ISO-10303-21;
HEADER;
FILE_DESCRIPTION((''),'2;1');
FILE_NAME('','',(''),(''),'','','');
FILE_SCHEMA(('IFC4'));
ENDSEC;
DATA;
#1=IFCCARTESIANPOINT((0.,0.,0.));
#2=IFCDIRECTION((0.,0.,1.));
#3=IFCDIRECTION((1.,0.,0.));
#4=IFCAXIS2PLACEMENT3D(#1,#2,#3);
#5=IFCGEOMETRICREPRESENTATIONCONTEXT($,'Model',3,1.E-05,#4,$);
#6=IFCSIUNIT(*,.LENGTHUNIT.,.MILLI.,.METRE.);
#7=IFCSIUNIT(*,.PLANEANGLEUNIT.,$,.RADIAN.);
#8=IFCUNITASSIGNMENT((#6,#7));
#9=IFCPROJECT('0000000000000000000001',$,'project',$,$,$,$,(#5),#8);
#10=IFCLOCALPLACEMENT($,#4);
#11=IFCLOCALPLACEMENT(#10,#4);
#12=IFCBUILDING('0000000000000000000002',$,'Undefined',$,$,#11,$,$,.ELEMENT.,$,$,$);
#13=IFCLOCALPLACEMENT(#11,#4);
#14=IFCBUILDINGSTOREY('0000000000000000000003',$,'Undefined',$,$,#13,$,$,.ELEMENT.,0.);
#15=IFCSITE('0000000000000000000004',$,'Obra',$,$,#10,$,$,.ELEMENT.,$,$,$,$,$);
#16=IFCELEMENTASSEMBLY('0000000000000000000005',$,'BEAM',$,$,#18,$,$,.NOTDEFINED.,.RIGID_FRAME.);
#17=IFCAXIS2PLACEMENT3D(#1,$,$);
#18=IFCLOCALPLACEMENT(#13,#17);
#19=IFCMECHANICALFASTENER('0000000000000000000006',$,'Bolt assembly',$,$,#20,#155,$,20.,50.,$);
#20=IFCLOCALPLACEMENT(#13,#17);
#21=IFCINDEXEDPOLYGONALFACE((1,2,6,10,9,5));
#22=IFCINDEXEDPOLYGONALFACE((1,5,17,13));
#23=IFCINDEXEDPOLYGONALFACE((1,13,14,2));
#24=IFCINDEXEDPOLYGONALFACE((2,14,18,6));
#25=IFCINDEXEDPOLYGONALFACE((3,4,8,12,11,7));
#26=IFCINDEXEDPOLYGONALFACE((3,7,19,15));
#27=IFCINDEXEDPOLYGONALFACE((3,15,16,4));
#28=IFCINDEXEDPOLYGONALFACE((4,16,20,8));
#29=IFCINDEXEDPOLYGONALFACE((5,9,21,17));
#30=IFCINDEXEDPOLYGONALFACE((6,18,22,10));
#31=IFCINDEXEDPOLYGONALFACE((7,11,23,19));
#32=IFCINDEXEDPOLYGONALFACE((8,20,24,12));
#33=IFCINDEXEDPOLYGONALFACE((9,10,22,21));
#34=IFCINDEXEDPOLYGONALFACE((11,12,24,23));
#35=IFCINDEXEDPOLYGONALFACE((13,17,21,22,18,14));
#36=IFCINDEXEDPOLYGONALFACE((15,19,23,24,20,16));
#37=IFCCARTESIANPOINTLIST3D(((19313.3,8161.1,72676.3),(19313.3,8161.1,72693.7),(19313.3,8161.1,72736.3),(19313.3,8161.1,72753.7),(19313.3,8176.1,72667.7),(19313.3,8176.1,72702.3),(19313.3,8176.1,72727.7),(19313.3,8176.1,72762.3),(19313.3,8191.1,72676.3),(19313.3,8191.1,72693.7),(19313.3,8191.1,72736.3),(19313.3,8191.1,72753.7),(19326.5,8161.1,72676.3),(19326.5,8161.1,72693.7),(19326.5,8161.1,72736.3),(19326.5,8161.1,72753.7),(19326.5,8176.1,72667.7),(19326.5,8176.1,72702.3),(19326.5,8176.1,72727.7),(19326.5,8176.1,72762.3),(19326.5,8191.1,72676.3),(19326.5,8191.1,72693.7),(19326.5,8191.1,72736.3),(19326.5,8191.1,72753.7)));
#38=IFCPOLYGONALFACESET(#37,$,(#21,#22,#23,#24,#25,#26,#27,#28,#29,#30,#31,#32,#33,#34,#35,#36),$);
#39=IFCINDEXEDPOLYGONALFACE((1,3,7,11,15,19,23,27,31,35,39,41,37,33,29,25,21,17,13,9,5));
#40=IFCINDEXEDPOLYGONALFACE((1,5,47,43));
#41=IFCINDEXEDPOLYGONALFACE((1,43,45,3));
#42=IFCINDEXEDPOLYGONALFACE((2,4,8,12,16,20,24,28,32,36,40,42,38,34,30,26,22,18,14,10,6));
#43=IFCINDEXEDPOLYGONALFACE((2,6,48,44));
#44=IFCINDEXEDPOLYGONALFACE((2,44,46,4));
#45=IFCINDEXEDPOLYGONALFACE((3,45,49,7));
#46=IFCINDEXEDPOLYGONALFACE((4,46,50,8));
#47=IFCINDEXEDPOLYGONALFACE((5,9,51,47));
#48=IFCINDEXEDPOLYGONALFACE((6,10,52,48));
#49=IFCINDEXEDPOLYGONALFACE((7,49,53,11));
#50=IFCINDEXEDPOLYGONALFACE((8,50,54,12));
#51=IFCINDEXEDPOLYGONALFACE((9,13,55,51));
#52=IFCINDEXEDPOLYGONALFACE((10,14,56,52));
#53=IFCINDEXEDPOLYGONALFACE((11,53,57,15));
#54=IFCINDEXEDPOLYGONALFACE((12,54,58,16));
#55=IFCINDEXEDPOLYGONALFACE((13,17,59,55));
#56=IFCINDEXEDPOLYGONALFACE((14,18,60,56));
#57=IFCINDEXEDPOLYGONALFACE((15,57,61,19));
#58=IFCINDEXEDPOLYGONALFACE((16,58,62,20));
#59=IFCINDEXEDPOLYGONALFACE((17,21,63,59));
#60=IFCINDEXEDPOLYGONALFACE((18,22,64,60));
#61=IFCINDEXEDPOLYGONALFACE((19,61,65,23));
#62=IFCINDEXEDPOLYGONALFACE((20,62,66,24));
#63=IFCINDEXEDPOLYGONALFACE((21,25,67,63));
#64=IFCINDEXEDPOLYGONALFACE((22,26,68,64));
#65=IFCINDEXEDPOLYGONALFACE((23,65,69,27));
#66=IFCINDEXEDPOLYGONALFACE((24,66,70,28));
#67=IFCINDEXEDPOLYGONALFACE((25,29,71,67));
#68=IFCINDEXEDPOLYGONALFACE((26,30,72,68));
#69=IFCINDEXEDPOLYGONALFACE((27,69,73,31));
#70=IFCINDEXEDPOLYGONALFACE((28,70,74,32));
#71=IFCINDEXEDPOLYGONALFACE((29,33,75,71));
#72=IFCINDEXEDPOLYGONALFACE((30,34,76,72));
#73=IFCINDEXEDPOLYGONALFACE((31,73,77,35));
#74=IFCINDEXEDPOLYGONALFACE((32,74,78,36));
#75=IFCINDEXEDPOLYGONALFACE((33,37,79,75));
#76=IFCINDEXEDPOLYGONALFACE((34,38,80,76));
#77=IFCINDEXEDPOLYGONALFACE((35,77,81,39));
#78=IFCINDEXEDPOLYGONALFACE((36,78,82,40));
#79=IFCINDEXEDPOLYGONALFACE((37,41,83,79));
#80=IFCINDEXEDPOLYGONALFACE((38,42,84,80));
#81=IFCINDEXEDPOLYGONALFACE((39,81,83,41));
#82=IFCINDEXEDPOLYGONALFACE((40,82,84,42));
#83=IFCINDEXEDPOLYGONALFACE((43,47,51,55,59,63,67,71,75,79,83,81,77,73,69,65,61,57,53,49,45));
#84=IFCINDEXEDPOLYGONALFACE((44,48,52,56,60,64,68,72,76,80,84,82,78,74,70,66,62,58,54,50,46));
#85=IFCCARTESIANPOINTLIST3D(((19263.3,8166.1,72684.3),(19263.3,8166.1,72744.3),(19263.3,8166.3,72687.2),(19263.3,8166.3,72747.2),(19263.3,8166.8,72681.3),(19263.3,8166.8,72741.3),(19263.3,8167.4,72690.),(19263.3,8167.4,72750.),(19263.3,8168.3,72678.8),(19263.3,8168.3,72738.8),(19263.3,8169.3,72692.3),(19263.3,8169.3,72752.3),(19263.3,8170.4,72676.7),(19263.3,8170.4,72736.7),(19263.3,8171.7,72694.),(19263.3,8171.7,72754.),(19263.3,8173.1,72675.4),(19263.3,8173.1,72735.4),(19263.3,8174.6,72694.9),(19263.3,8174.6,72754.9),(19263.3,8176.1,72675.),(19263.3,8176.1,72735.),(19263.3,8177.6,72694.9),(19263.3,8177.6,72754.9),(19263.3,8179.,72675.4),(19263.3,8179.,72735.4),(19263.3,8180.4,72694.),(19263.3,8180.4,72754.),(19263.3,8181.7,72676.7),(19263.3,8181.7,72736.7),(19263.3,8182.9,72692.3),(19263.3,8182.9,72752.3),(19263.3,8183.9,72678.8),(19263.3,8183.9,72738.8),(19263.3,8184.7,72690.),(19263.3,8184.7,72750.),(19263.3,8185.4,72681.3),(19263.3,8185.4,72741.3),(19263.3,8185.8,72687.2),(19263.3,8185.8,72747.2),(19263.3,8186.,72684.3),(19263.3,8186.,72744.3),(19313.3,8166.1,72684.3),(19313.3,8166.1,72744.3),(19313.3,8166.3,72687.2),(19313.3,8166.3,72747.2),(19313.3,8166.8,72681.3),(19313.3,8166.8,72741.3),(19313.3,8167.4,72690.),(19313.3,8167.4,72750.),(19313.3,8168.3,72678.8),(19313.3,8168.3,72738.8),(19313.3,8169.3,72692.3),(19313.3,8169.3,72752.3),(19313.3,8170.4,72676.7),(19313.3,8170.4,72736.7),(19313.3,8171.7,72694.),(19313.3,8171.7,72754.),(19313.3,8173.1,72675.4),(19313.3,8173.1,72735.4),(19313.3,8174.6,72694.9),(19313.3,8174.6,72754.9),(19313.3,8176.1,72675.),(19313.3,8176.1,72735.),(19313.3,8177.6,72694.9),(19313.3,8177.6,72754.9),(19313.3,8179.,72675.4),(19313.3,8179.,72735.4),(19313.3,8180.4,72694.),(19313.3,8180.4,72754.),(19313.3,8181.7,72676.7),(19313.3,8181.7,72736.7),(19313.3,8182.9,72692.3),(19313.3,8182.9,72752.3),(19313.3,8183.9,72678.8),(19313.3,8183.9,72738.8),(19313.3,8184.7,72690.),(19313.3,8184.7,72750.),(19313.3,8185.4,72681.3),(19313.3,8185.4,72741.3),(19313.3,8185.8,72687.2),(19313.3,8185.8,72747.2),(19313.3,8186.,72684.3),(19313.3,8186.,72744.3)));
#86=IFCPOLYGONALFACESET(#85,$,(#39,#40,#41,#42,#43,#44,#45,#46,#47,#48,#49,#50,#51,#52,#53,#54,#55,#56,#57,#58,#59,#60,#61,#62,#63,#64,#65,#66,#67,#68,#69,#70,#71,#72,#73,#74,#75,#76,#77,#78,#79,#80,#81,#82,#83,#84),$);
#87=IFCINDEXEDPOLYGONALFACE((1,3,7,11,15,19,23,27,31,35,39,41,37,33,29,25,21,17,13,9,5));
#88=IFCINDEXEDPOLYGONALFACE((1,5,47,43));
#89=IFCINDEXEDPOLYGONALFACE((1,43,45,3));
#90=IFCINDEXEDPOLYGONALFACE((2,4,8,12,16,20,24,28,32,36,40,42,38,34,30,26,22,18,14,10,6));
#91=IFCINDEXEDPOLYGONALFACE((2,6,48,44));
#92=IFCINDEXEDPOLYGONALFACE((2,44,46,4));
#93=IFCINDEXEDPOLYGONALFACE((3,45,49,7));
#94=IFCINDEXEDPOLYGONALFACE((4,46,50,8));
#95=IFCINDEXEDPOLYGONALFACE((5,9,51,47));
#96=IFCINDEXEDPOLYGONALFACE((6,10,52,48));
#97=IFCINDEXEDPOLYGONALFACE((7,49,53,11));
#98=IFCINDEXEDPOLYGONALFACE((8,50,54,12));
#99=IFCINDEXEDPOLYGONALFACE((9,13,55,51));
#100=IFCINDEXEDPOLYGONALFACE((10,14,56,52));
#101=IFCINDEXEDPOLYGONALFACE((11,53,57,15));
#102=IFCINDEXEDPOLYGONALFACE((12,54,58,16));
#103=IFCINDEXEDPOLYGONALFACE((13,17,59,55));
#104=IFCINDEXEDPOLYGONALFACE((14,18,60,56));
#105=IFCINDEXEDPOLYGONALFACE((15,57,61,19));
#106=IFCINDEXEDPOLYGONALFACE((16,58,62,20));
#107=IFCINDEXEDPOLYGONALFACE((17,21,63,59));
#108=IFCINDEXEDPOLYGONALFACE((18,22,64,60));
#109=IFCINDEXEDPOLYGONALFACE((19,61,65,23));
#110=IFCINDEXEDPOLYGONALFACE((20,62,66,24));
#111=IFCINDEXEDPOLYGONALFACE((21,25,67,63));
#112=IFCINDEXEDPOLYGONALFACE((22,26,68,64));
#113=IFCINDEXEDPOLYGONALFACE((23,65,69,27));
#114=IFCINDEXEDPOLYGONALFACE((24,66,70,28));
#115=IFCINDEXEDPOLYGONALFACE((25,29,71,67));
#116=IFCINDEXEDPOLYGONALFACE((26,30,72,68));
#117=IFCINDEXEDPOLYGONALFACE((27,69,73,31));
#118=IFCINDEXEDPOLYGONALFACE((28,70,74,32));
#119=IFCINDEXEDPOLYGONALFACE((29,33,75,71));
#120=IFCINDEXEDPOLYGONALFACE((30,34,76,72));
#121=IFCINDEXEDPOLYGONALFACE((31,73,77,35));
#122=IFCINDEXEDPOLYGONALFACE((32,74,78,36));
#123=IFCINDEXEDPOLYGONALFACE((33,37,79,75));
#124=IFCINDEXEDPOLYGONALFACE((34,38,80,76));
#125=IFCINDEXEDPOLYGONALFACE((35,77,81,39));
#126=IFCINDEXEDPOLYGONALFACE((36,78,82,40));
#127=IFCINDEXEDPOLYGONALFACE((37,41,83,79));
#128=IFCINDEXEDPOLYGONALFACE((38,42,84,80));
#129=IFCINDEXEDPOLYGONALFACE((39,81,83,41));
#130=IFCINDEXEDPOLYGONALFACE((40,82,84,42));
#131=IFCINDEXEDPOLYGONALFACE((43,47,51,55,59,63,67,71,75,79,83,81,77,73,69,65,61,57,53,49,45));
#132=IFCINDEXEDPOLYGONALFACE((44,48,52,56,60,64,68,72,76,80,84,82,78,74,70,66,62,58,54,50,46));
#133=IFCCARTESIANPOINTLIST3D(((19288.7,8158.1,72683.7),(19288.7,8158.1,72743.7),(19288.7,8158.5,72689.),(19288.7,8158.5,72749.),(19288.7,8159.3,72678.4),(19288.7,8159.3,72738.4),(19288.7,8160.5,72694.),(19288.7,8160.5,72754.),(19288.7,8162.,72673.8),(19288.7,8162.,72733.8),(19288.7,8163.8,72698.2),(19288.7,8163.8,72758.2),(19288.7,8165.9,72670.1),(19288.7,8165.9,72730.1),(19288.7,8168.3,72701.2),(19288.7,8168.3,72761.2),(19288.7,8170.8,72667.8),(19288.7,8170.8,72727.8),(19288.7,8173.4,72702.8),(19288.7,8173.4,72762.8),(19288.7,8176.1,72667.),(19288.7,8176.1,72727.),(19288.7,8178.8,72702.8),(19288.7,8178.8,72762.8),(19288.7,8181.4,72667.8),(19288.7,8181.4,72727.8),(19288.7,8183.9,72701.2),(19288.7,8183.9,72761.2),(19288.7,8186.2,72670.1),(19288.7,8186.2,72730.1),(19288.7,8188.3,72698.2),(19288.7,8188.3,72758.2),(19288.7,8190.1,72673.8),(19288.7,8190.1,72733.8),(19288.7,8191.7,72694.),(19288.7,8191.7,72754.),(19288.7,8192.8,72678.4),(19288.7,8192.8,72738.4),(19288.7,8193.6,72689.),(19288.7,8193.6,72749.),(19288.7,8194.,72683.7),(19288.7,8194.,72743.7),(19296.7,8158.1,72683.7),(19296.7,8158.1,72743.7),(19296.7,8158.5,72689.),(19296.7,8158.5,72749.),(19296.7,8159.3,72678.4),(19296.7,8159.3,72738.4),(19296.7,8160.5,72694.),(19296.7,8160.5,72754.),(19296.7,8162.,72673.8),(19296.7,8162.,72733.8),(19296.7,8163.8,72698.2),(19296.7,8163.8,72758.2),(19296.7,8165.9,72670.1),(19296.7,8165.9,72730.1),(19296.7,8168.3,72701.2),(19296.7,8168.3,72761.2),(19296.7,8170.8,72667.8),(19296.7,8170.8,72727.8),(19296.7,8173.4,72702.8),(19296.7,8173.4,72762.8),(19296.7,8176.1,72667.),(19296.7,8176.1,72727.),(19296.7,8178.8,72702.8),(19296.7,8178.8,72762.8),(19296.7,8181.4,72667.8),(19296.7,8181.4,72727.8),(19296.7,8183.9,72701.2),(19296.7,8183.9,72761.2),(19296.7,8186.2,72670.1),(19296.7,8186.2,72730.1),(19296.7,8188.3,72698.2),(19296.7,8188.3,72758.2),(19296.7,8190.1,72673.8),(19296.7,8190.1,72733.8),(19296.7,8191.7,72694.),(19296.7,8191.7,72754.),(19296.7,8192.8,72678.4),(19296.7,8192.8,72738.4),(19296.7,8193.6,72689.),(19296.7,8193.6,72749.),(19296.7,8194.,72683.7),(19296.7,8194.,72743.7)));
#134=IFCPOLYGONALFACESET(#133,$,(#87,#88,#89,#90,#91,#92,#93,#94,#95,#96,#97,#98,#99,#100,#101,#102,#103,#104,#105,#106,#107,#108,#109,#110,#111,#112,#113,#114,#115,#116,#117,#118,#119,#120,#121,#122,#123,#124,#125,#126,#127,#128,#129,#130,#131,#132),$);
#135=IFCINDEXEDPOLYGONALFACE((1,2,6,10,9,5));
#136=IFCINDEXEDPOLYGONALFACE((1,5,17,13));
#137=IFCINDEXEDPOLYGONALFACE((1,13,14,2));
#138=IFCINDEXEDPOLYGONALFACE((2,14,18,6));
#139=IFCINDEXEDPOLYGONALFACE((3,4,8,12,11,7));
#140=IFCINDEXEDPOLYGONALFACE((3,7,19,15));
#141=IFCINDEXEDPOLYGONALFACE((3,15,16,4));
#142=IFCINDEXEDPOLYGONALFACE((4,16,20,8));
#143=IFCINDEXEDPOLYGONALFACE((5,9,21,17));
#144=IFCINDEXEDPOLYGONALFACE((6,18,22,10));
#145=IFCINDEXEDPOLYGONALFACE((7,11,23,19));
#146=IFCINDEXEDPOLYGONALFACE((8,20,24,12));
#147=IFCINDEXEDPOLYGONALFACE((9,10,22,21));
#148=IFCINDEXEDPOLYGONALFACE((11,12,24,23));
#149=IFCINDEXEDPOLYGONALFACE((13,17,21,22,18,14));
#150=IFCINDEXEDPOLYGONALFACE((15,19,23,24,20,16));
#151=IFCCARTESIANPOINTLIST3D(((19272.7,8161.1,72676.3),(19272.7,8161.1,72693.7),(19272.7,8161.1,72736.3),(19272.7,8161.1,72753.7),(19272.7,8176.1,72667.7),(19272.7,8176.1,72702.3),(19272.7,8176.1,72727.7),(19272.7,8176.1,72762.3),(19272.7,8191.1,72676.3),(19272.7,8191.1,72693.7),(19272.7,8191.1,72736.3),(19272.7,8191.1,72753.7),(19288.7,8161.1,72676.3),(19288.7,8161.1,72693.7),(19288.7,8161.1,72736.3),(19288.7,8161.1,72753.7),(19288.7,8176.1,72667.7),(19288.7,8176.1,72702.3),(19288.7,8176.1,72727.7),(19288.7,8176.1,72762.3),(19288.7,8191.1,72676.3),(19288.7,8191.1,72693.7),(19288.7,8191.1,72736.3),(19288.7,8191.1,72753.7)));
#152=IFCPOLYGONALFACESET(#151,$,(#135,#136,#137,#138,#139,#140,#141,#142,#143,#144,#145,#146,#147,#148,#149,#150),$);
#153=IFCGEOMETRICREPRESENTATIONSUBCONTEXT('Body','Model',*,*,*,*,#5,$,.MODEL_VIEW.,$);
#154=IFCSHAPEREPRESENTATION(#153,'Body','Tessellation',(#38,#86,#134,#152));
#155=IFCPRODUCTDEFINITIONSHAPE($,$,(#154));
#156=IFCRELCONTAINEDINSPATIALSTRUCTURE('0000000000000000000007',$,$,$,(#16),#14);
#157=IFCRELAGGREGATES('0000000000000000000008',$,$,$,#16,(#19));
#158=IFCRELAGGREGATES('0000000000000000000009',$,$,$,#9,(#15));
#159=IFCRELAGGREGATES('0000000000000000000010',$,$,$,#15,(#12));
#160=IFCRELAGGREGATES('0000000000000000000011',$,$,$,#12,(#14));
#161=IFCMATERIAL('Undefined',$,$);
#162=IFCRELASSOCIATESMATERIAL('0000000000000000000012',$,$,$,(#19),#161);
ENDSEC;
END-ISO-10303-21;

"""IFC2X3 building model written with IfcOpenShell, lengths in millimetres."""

from ifc_helpers import new_model, si_unit, frame, origin_with_axes, origin_2d_with_axis, place, context, subcontext, project, spatial, polyline, circle, outline, extrude, source, transform, mapped, material, element, aggregate, save


model = new_model("IFC2X3")

# Units and contexts
model_context = context("Model", 3, precision=1e-05, world=origin_with_axes())
body_context = subcontext(model_context, "Body", "Model", "MODEL_VIEW")
ifc_project = project(units=[si_unit("LENGTHUNIT", "METRE", prefix="MILLI"), si_unit("PLANEANGLEUNIT", "RADIAN")], contexts=[model_context])

# Site, building, storey
site_placement = place(None, origin_with_axes())
site = spatial("IfcSite", under=ifc_project, at=site_placement, Name="Obra", CompositionType="ELEMENT")
building_placement = place(site_placement, origin_with_axes())
building = spatial("IfcBuilding", under=site, at=building_placement, Name="Undefined", CompositionType="ELEMENT")
storey_placement = place(building_placement, origin_with_axes())
storey = spatial("IfcBuildingStorey", under=building, at=storey_placement, Name="Undefined", CompositionType="ELEMENT", Elevation=0.0)

# Shared definitions
ifc_material = material(Name="Undefined")

# Shared definitions
shared_shape_1 = source(origin_with_axes(), body_context, "Body", "SweptSolid", [
    extrude(outline(polyline([(17.3, 0.0), (8.7, 15.0), (-8.7, 15.0), (-17.3, 0.0), (-8.7, -15.0), (8.7, -15.0), (17.3, 0.0)])), frame((0.0, -26.5, 0.0), z_axis=(0.0, 1.0, 0.0), x_axis=(1.0, 0.0, 0.0)), (0.0, 0.0, 1.0), 13.2),
    extrude(circle(Radius=10.0, at=origin_2d_with_axis()), frame((0.0, -13.3, 0.0), z_axis=(0.0, 1.0, 0.0), x_axis=(1.0, 0.0, 0.0)), (0.0, 0.0, 1.0), 50.0),
    extrude(circle(Radius=18.0, at=origin_2d_with_axis()), frame((0.0, 3.3, 0.0), z_axis=(0.0, 1.0, 0.0), x_axis=(1.0, 0.0, 0.0)), (0.0, 0.0, 1.0), 8.0),
    extrude(outline(polyline([(17.3, 0.0), (8.7, 15.0), (-8.7, 15.0), (-17.3, 0.0), (-8.7, -15.0), (8.7, -15.0), (17.3, 0.0)])), frame((0.0, 11.3, 0.0), z_axis=(0.0, 1.0, 0.0), x_axis=(1.0, 0.0, 0.0)), (0.0, 0.0, 1.0), 16.0),
])

# Element assembly, mechanical fastener
assembly_1_placement = place(storey_placement, origin_with_axes())
assembly_1 = element("IfcElementAssembly", 1, at=assembly_1_placement, inside=storey, Name="BEAM", AssemblyPlace="NOTDEFINED", PredefinedType="RIGID_FRAME")
mechanical_fastener_1_placement = place(assembly_1_placement, frame((19300.0, 8136.1, 72850.0), z_axis=(0.0, 1.0, 0.0), x_axis=(0.0, 0.0, -1.0)))
mechanical_fastener_1 = element("IfcMechanicalFastener", 2, at=mechanical_fastener_1_placement, material=ifc_material, Name="Bolt assembly", NominalDiameter=20.0, NominalLength=50.0, context=body_context, shape_type="MappedRepresentation", body=[
    mapped(shared_shape_1, transform((105.0, 0.0, 40.0))),
    mapped(shared_shape_1, transform((165.0, 0.0, 40.0))),
])
aggregate(assembly_1, [mechanical_fastener_1])

save(model, "model.ifc")
